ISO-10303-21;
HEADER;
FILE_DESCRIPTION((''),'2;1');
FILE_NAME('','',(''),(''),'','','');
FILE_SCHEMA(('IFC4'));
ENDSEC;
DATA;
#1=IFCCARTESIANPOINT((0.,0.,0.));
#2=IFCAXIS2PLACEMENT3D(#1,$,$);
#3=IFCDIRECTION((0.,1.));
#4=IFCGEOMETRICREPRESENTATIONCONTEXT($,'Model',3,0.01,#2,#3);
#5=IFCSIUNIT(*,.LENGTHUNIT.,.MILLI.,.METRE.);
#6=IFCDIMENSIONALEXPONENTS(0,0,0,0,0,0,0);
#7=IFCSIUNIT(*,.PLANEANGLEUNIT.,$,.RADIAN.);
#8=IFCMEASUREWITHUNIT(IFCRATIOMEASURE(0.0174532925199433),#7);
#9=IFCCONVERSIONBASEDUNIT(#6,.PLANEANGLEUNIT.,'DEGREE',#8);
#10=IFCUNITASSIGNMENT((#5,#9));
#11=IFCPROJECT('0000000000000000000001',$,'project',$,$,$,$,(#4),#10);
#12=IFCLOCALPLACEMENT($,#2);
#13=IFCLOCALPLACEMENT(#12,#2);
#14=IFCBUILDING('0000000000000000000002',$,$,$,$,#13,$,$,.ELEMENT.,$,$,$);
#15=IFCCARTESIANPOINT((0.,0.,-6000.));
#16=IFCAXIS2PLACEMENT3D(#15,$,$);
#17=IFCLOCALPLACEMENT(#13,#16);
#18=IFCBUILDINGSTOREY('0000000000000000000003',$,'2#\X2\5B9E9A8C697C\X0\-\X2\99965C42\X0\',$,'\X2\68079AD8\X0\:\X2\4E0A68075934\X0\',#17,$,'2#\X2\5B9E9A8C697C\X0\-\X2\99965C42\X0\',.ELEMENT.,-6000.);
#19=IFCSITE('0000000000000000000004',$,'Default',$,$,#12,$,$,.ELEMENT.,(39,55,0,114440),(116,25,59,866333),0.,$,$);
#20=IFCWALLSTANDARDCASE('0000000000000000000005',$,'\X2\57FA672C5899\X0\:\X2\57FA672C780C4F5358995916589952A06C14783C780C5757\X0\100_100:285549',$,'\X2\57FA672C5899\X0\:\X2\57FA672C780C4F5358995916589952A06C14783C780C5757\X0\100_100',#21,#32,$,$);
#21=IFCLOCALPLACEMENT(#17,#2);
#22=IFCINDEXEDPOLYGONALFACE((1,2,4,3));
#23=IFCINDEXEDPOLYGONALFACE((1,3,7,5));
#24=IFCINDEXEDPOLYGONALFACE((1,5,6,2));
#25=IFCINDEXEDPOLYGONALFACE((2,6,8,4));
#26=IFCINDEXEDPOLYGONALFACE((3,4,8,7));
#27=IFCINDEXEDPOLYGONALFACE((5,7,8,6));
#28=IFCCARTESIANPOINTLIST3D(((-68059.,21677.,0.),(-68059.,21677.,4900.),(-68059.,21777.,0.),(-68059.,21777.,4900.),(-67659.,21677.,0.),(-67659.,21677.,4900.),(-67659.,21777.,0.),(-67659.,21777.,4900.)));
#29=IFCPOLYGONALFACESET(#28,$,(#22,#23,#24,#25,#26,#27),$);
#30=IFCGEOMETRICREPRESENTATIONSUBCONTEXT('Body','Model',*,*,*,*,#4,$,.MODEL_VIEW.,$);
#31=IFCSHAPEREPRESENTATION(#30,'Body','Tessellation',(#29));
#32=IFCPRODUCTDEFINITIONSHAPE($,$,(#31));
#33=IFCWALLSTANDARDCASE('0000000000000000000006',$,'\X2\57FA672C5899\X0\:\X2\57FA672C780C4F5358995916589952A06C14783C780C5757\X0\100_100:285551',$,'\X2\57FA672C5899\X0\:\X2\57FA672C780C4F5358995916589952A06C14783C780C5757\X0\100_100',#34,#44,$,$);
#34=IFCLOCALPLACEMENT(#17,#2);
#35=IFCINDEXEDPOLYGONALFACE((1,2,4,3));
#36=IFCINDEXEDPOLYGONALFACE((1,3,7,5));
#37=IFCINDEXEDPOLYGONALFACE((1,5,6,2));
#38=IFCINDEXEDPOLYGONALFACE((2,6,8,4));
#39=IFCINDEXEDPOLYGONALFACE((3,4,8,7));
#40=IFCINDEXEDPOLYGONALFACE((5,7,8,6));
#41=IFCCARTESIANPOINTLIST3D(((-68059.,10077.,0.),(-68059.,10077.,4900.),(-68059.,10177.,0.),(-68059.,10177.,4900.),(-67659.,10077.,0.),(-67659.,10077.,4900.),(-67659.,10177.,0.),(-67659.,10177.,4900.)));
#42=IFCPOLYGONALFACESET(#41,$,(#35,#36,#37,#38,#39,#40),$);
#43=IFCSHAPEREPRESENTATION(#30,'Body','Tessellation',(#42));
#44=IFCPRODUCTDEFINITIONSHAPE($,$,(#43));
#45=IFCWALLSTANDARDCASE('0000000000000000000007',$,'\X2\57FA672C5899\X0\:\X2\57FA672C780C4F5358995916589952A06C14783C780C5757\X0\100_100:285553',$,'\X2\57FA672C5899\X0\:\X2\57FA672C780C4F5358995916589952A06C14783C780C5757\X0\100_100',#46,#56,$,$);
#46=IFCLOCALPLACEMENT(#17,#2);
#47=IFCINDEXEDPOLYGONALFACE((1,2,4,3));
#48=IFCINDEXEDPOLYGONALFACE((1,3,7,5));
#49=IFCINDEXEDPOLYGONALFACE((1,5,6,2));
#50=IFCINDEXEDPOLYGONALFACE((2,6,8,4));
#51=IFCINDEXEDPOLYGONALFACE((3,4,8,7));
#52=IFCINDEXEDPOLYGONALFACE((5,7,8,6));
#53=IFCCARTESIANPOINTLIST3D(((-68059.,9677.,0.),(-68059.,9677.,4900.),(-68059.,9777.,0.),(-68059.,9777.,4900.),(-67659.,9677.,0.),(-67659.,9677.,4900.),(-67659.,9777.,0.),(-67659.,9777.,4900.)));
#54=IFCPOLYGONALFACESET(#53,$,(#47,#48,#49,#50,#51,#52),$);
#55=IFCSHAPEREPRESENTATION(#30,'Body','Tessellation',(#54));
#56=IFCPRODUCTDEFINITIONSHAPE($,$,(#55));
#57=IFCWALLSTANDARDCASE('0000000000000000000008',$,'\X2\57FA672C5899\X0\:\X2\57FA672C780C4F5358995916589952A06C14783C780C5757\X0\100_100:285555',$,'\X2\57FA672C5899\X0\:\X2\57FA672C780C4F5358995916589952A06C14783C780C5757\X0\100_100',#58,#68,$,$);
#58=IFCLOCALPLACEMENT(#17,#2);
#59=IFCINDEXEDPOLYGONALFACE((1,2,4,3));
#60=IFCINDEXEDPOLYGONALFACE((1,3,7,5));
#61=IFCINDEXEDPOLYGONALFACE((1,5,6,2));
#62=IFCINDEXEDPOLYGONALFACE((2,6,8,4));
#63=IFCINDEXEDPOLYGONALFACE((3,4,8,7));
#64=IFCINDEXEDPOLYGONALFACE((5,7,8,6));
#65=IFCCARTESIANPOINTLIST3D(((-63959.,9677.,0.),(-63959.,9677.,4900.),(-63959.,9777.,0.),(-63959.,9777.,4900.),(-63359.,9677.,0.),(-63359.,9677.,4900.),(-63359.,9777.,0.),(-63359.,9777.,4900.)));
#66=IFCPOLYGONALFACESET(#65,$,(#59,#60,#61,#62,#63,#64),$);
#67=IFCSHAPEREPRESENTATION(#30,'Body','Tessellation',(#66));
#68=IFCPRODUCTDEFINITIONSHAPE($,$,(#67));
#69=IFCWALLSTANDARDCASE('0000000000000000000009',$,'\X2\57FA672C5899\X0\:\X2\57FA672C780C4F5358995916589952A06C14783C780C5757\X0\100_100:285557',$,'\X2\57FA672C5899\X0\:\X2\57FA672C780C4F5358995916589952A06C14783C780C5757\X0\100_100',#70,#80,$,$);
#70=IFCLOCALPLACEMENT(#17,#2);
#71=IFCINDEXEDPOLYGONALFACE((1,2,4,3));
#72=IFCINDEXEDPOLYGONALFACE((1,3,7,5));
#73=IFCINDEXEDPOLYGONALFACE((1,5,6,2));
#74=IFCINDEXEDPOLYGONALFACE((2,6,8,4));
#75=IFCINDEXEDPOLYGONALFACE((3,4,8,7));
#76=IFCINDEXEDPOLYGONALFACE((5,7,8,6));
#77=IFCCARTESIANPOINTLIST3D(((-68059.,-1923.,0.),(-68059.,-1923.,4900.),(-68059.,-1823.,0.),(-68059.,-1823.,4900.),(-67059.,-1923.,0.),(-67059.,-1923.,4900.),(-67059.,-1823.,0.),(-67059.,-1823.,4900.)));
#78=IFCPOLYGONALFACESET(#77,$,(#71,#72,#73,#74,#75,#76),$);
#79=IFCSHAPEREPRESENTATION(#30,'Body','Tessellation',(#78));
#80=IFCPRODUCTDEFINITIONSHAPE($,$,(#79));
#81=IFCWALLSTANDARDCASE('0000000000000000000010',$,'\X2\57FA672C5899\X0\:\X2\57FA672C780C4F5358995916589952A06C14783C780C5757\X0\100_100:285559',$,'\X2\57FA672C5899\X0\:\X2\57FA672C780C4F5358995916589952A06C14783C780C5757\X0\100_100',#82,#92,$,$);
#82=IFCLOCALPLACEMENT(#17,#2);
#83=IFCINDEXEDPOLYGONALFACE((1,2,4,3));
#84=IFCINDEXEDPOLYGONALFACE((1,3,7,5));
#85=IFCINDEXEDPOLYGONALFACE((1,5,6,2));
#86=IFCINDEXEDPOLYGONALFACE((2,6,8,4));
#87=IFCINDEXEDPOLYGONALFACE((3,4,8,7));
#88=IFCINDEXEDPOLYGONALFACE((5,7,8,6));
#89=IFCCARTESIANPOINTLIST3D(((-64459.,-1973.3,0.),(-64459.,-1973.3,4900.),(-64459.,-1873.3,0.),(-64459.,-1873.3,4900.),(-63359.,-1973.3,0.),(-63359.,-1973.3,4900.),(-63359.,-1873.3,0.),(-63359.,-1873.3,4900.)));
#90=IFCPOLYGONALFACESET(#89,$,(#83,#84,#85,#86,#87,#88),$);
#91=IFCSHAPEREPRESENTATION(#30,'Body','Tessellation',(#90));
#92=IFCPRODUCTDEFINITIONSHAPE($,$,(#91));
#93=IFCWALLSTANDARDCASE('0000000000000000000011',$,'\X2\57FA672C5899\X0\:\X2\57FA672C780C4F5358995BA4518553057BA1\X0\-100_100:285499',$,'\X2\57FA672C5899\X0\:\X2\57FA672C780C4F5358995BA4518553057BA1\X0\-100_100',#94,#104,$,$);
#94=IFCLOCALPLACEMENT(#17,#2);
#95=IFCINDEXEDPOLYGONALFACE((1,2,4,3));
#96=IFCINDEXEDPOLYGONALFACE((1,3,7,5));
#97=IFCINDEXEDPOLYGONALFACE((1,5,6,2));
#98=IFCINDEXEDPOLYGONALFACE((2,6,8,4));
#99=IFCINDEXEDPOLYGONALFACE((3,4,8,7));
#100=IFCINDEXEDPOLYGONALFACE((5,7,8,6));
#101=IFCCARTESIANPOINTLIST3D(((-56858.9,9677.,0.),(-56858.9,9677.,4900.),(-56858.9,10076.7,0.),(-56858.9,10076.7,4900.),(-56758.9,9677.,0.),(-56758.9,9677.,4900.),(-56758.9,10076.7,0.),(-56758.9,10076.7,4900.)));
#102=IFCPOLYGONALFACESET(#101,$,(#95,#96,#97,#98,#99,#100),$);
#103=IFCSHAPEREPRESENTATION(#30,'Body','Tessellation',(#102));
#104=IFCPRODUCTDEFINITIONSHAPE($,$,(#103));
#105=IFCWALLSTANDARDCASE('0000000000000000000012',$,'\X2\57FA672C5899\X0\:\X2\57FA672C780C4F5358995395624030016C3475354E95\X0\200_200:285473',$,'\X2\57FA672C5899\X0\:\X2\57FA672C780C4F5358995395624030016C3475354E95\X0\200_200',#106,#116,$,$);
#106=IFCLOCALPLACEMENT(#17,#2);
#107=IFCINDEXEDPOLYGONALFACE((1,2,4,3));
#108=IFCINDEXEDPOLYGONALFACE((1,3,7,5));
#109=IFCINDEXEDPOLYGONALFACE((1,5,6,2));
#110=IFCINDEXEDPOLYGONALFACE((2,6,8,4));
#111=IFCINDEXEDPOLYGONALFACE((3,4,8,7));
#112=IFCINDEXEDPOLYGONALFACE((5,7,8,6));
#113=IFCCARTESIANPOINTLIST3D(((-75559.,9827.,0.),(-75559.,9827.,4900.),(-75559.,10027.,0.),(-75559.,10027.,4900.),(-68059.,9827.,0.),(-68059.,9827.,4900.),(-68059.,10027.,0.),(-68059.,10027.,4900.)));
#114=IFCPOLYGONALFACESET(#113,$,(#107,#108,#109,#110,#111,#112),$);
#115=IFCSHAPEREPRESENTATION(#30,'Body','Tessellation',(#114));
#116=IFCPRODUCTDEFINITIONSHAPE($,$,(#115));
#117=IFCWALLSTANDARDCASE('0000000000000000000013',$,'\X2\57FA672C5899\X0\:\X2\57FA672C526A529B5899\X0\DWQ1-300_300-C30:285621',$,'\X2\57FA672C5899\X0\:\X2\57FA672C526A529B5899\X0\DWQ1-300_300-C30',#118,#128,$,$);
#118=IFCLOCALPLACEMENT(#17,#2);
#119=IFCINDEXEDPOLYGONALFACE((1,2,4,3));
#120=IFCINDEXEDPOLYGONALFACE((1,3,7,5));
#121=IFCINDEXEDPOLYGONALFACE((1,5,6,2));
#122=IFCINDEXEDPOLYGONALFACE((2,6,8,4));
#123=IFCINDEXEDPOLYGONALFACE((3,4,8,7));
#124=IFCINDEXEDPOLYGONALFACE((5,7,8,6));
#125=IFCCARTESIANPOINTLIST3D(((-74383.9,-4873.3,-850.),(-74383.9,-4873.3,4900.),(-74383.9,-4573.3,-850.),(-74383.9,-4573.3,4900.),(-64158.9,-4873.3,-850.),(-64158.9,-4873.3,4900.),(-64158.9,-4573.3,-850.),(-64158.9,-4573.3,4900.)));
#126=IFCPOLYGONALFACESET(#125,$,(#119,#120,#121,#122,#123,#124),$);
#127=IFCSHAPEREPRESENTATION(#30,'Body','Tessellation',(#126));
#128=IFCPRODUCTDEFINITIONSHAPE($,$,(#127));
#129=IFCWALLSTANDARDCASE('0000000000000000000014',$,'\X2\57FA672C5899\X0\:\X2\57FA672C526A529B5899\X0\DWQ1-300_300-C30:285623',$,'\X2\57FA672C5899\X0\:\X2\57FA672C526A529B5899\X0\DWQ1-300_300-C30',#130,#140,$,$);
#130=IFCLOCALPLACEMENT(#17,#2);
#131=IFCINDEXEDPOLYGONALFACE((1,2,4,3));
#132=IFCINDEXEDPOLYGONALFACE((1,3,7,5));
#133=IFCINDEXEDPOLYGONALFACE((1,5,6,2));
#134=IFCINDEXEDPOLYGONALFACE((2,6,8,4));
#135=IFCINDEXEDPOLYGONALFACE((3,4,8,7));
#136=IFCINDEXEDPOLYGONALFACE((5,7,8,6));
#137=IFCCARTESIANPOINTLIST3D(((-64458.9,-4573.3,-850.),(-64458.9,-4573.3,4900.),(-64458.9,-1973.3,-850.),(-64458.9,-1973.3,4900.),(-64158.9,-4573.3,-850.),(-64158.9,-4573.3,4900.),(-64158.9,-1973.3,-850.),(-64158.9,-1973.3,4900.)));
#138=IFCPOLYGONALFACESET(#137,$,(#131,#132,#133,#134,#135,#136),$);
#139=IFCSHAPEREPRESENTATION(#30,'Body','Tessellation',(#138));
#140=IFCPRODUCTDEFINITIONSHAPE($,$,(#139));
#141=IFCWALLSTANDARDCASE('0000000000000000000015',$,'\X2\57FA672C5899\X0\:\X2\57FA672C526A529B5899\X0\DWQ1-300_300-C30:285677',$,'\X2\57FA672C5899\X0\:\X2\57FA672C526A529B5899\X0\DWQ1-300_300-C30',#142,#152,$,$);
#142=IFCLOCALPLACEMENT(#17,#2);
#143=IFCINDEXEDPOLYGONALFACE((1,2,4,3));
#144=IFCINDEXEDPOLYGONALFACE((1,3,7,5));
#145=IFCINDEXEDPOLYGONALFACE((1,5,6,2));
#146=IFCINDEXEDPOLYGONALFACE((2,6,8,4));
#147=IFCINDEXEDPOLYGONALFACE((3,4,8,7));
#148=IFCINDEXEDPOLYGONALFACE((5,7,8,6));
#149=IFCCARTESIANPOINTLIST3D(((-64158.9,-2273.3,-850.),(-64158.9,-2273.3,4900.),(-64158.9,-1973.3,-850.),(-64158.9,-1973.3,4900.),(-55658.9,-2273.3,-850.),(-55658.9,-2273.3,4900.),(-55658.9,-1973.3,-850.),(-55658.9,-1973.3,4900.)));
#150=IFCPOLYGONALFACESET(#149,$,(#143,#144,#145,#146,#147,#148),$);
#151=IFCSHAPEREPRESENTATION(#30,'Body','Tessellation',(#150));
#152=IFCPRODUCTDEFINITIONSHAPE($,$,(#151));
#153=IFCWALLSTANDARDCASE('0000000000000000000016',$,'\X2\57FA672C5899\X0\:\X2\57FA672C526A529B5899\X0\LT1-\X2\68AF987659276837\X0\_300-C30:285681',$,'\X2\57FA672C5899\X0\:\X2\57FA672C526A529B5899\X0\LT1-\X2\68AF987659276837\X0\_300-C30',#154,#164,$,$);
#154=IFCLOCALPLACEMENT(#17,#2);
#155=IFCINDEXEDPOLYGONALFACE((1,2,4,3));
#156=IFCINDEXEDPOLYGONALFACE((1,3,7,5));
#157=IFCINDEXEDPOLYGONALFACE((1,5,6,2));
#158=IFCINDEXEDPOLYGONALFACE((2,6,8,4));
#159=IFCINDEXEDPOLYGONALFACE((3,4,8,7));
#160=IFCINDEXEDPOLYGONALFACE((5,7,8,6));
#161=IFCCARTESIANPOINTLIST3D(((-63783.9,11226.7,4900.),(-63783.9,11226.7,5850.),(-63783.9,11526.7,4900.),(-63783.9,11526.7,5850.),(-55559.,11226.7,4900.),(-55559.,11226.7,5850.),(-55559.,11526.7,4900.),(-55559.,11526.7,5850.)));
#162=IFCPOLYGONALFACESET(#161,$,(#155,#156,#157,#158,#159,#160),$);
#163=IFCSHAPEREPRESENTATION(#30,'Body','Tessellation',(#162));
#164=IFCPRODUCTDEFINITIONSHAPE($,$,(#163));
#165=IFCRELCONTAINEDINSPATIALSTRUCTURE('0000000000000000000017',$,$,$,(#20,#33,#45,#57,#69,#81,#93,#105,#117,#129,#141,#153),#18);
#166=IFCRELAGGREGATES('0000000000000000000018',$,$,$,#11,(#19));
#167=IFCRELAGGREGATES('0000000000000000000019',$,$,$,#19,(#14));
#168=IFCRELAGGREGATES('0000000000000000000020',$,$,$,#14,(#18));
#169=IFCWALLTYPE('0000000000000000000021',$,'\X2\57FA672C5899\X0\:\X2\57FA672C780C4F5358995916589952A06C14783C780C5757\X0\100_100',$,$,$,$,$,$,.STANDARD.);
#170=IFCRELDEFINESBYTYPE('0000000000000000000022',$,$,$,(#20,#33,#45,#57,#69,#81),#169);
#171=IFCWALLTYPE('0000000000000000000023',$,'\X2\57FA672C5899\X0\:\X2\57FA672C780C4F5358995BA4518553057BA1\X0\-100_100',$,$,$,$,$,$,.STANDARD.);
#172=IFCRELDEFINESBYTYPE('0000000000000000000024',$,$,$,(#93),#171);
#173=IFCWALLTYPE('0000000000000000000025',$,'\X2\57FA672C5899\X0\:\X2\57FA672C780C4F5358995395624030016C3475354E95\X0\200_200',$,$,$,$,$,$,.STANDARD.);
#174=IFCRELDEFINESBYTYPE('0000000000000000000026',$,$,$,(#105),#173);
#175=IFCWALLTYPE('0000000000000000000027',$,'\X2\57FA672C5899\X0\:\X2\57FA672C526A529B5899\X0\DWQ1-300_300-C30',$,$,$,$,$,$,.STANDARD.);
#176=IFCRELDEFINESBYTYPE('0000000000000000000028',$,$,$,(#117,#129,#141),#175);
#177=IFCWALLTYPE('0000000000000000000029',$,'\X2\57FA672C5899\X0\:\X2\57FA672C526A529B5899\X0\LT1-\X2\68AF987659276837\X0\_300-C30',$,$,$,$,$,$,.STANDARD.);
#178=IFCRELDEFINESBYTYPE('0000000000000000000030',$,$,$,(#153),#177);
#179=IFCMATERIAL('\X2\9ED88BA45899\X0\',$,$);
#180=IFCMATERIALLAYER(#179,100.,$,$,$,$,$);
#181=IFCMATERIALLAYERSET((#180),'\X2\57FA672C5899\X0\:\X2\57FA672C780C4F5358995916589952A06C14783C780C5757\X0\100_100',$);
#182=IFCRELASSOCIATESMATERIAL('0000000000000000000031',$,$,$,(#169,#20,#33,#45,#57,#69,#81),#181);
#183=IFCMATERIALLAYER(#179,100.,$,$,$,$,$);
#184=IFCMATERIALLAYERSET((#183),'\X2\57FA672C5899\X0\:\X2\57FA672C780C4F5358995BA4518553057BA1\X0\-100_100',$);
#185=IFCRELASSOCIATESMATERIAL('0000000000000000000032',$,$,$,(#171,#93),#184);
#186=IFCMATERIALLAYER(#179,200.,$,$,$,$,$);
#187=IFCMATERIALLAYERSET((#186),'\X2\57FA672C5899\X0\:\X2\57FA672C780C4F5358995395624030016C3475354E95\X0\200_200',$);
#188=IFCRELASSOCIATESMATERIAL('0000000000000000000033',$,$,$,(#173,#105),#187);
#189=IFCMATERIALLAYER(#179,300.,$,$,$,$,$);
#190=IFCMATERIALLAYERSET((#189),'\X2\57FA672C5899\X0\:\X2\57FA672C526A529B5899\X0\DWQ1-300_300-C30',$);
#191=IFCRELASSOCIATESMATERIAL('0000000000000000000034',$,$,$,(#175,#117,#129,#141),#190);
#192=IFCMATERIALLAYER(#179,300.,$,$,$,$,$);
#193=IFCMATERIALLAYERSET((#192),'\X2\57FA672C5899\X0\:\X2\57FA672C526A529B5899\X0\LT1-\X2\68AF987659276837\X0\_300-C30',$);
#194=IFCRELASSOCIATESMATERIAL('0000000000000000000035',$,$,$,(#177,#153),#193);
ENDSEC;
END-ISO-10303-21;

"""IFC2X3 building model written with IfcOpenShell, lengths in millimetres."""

from ifc_helpers import new_model, entity, si_unit, converted_unit, direction, frame, frame_2d, origin, place, context, subcontext, project, spatial, rectangle, extrude, material, layer, layer_set, layer_usage, type_object, element, save


model = new_model("IFC2X3")

# Units and contexts
model_context = context("Model", 3, precision=0.01, world=origin(), true_north=direction((0.0, 1.0)))
body_context = subcontext(model_context, "Body", "Model", "MODEL_VIEW")
ifc_project = project(units=[si_unit("LENGTHUNIT", "METRE", prefix="MILLI"), converted_unit("PLANEANGLEUNIT", "DEGREE", entity("IfcRatioMeasure", 0.0174532925199433), si_unit("PLANEANGLEUNIT", "RADIAN"), dimensions=[0, 0, 0, 0, 0, 0, 0])], contexts=[model_context])

# Site, building, storey
site_placement = place(None, origin())
site = spatial("IfcSite", under=ifc_project, at=site_placement, Name="Default", CompositionType="ELEMENT", RefLatitude=(39, 55, 0, 114440), RefLongitude=(116, 25, 59, 866333), RefElevation=0.0)
building_placement = place(site_placement, origin())
building = spatial("IfcBuilding", under=site, at=building_placement, CompositionType="ELEMENT")
storey_placement = place(building_placement, frame((0.0, 0.0, -6000.0)))
storey = spatial("IfcBuildingStorey", under=building, at=storey_placement, Name="2#实验楼-首层", ObjectType="标高:上标头", LongName="2#实验楼-首层", CompositionType="ELEMENT", Elevation=-6000.0)

# Walls
ifc_material_1 = material(Name="默认墙")
ifc_layer_1 = layer(ifc_material_1, 100.0)
ifc_layer_set_1 = layer_set([ifc_layer_1], Name="基本墙:基本砌体墙外墙加气砼砌块100_100")
ifc_layer_usage_1 = layer_usage(ifc_layer_set_1, "AXIS2", "NEGATIVE", 50.0)
wall_type_1 = type_object("IfcWallType", Name="基本墙:基本砌体墙外墙加气砼砌块100_100", PredefinedType="STANDARD", material=ifc_layer_set_1)
wall_1_placement = place(storey_placement, frame((-68059.0, 21727.0, 0.0)))
element("IfcWallStandardCase", 1, at=wall_1_placement, inside=storey, type_object=wall_type_1, material=ifc_layer_usage_1, Name="基本墙:基本砌体墙外墙加气砼砌块100_100:285549", ObjectType="基本墙:基本砌体墙外墙加气砼砌块100_100", context=body_context, shape_type="SweptSolid", body=[
    extrude(rectangle(XDim=400.0, YDim=100.0, at=frame_2d((200.0, 0.0), x_axis=(-1.0, 0.0))), origin(), (0.0, 0.0, 1.0), 4900.0),
])
ifc_layer_usage_2 = layer_usage(ifc_layer_set_1, "AXIS2", "NEGATIVE", 50.0)
wall_2_placement = place(storey_placement, frame((-68059.0, 10127.0, 0.0)))
element("IfcWallStandardCase", 2, at=wall_2_placement, inside=storey, type_object=wall_type_1, material=ifc_layer_usage_2, Name="基本墙:基本砌体墙外墙加气砼砌块100_100:285551", ObjectType="基本墙:基本砌体墙外墙加气砼砌块100_100", context=body_context, shape_type="SweptSolid", body=[
    extrude(rectangle(XDim=400.0, YDim=100.0, at=frame_2d((200.0, 0.0), x_axis=(-1.0, 0.0))), origin(), (0.0, 0.0, 1.0), 4900.0),
])
ifc_layer_usage_3 = layer_usage(ifc_layer_set_1, "AXIS2", "NEGATIVE", 50.0)
wall_3_placement = place(storey_placement, frame((-68059.0, 9727.0, 0.0)))
element("IfcWallStandardCase", 3, at=wall_3_placement, inside=storey, type_object=wall_type_1, material=ifc_layer_usage_3, Name="基本墙:基本砌体墙外墙加气砼砌块100_100:285553", ObjectType="基本墙:基本砌体墙外墙加气砼砌块100_100", context=body_context, shape_type="SweptSolid", body=[
    extrude(rectangle(XDim=400.0, YDim=100.0, at=frame_2d((200.0, 0.0), x_axis=(-1.0, 0.0))), origin(), (0.0, 0.0, 1.0), 4900.0),
])
ifc_layer_usage_4 = layer_usage(ifc_layer_set_1, "AXIS2", "NEGATIVE", 50.0)
wall_4_placement = place(storey_placement, frame((-63959.0, 9727.0, 0.0)))
element("IfcWallStandardCase", 4, at=wall_4_placement, inside=storey, type_object=wall_type_1, material=ifc_layer_usage_4, Name="基本墙:基本砌体墙外墙加气砼砌块100_100:285555", ObjectType="基本墙:基本砌体墙外墙加气砼砌块100_100", context=body_context, shape_type="SweptSolid", body=[
    extrude(rectangle(XDim=600.0, YDim=100.0, at=frame_2d((300.0, 0.0), x_axis=(-1.0, 0.0))), origin(), (0.0, 0.0, 1.0), 4900.0),
])
ifc_layer_usage_5 = layer_usage(ifc_layer_set_1, "AXIS2", "NEGATIVE", 50.0)
wall_5_placement = place(storey_placement, frame((-68059.0, -1873.0, 0.0)))
element("IfcWallStandardCase", 5, at=wall_5_placement, inside=storey, type_object=wall_type_1, material=ifc_layer_usage_5, Name="基本墙:基本砌体墙外墙加气砼砌块100_100:285557", ObjectType="基本墙:基本砌体墙外墙加气砼砌块100_100", context=body_context, shape_type="SweptSolid", body=[
    extrude(rectangle(XDim=1000.0, YDim=100.0, at=frame_2d((500.0, 0.0), x_axis=(-1.0, 0.0))), origin(), (0.0, 0.0, 1.0), 4900.0),
])
ifc_layer_usage_6 = layer_usage(ifc_layer_set_1, "AXIS2", "NEGATIVE", 50.0)
wall_6_placement = place(storey_placement, frame((-64459.0, -1923.3, 0.0)))
element("IfcWallStandardCase", 6, at=wall_6_placement, inside=storey, type_object=wall_type_1, material=ifc_layer_usage_6, Name="基本墙:基本砌体墙外墙加气砼砌块100_100:285559", ObjectType="基本墙:基本砌体墙外墙加气砼砌块100_100", context=body_context, shape_type="SweptSolid", body=[
    extrude(rectangle(XDim=1100.0, YDim=100.0, at=frame_2d((550.0, 0.0), x_axis=(-1.0, 0.0))), origin(), (0.0, 0.0, 1.0), 4900.0),
])
ifc_layer_2 = layer(ifc_material_1, 100.0)
ifc_layer_set_2 = layer_set([ifc_layer_2], Name="基本墙:基本砌体墙室内包管-100_100")
ifc_layer_usage_7 = layer_usage(ifc_layer_set_2, "AXIS2", "NEGATIVE", 50.0)
wall_type_2 = type_object("IfcWallType", Name="基本墙:基本砌体墙室内包管-100_100", PredefinedType="STANDARD", material=ifc_layer_set_2)
wall_7_placement = place(storey_placement, frame((-56808.9, 10076.7, 0.0), z_axis=(0.0, 0.0, 1.0), x_axis=(0.0, -1.0, 0.0)))
element("IfcWallStandardCase", 7, at=wall_7_placement, inside=storey, type_object=wall_type_2, material=ifc_layer_usage_7, Name="基本墙:基本砌体墙室内包管-100_100:285499", ObjectType="基本墙:基本砌体墙室内包管-100_100", context=body_context, shape_type="SweptSolid", body=[
    extrude(rectangle(XDim=399.7, YDim=100.0, at=frame_2d((199.8, 0.0), x_axis=(-1.0, 0.0))), origin(), (0.0, 0.0, 1.0), 4900.0),
])
ifc_layer_3 = layer(ifc_material_1, 200.0)
ifc_layer_set_3 = layer_set([ifc_layer_3], Name="基本墙:基本砌体墙厕所、水电井200_200")
ifc_layer_usage_8 = layer_usage(ifc_layer_set_3, "AXIS2", "NEGATIVE", 100.0)
wall_type_3 = type_object("IfcWallType", Name="基本墙:基本砌体墙厕所、水电井200_200", PredefinedType="STANDARD", material=ifc_layer_set_3)
wall_8_placement = place(storey_placement, frame((-75559.0, 9927.0, 0.0)))
element("IfcWallStandardCase", 8, at=wall_8_placement, inside=storey, type_object=wall_type_3, material=ifc_layer_usage_8, Name="基本墙:基本砌体墙厕所、水电井200_200:285473", ObjectType="基本墙:基本砌体墙厕所、水电井200_200", context=body_context, shape_type="SweptSolid", body=[
    extrude(rectangle(XDim=7500.0, YDim=200.0, at=frame_2d((3750.0, 0.0), x_axis=(-1.0, 0.0))), origin(), (0.0, 0.0, 1.0), 4900.0),
])
ifc_layer_4 = layer(ifc_material_1, 300.0)
ifc_layer_set_4 = layer_set([ifc_layer_4], Name="基本墙:基本剪力墙DWQ1-300_300-C30")
ifc_layer_usage_9 = layer_usage(ifc_layer_set_4, "AXIS2", "NEGATIVE", 150.0)
wall_type_4 = type_object("IfcWallType", Name="基本墙:基本剪力墙DWQ1-300_300-C30", PredefinedType="STANDARD", material=ifc_layer_set_4)
wall_9_placement = place(storey_placement, frame((-74383.9, -4723.3, -850.0)))
element("IfcWallStandardCase", 9, at=wall_9_placement, inside=storey, type_object=wall_type_4, material=ifc_layer_usage_9, Name="基本墙:基本剪力墙DWQ1-300_300-C30:285621", ObjectType="基本墙:基本剪力墙DWQ1-300_300-C30", context=body_context, shape_type="SweptSolid", body=[
    extrude(rectangle(XDim=10225.0, YDim=300.0, at=frame_2d((5112.5, 0.0), x_axis=(-1.0, 0.0))), origin(), (0.0, 0.0, 1.0), 5750.0),
])
ifc_layer_usage_10 = layer_usage(ifc_layer_set_4, "AXIS2", "NEGATIVE", 150.0)
wall_10_placement = place(storey_placement, frame((-64308.9, -4573.3, -850.0), z_axis=(0.0, 0.0, 1.0), x_axis=(0.0, 1.0, 0.0)))
element("IfcWallStandardCase", 10, at=wall_10_placement, inside=storey, type_object=wall_type_4, material=ifc_layer_usage_10, Name="基本墙:基本剪力墙DWQ1-300_300-C30:285623", ObjectType="基本墙:基本剪力墙DWQ1-300_300-C30", context=body_context, shape_type="SweptSolid", body=[
    extrude(rectangle(XDim=2600.0, YDim=300.0, at=frame_2d((1300.0, 0.0), x_axis=(-1.0, 0.0))), origin(), (0.0, 0.0, 1.0), 5750.0),
])
ifc_layer_usage_11 = layer_usage(ifc_layer_set_4, "AXIS2", "NEGATIVE", 150.0)
wall_11_placement = place(storey_placement, frame((-64158.9, -2123.3, -850.0)))
element("IfcWallStandardCase", 11, at=wall_11_placement, inside=storey, type_object=wall_type_4, material=ifc_layer_usage_11, Name="基本墙:基本剪力墙DWQ1-300_300-C30:285677", ObjectType="基本墙:基本剪力墙DWQ1-300_300-C30", context=body_context, shape_type="SweptSolid", body=[
    extrude(rectangle(XDim=8500.0, YDim=300.0, at=frame_2d((4250.0, 0.0), x_axis=(-1.0, 0.0))), origin(), (0.0, 0.0, 1.0), 5750.0),
])
ifc_layer_5 = layer(ifc_material_1, 300.0)
ifc_layer_set_5 = layer_set([ifc_layer_5], Name="基本墙:基本剪力墙LT1-梯顶大样_300-C30")
ifc_layer_usage_12 = layer_usage(ifc_layer_set_5, "AXIS2", "NEGATIVE", 150.0)
wall_type_5 = type_object("IfcWallType", Name="基本墙:基本剪力墙LT1-梯顶大样_300-C30", PredefinedType="STANDARD", material=ifc_layer_set_5)
wall_12_placement = place(storey_placement, frame((-63783.9, 11376.7, 4900.0)))
element("IfcWallStandardCase", 12, at=wall_12_placement, inside=storey, type_object=wall_type_5, material=ifc_layer_usage_12, Name="基本墙:基本剪力墙LT1-梯顶大样_300-C30:285681", ObjectType="基本墙:基本剪力墙LT1-梯顶大样_300-C30", context=body_context, shape_type="SweptSolid", body=[
    extrude(rectangle(XDim=8224.9, YDim=300.0, at=frame_2d((4112.5, 0.0), x_axis=(-1.0, 0.0))), origin(), (0.0, 0.0, 1.0), 950.0),
])

save(model, "model.ifc")
